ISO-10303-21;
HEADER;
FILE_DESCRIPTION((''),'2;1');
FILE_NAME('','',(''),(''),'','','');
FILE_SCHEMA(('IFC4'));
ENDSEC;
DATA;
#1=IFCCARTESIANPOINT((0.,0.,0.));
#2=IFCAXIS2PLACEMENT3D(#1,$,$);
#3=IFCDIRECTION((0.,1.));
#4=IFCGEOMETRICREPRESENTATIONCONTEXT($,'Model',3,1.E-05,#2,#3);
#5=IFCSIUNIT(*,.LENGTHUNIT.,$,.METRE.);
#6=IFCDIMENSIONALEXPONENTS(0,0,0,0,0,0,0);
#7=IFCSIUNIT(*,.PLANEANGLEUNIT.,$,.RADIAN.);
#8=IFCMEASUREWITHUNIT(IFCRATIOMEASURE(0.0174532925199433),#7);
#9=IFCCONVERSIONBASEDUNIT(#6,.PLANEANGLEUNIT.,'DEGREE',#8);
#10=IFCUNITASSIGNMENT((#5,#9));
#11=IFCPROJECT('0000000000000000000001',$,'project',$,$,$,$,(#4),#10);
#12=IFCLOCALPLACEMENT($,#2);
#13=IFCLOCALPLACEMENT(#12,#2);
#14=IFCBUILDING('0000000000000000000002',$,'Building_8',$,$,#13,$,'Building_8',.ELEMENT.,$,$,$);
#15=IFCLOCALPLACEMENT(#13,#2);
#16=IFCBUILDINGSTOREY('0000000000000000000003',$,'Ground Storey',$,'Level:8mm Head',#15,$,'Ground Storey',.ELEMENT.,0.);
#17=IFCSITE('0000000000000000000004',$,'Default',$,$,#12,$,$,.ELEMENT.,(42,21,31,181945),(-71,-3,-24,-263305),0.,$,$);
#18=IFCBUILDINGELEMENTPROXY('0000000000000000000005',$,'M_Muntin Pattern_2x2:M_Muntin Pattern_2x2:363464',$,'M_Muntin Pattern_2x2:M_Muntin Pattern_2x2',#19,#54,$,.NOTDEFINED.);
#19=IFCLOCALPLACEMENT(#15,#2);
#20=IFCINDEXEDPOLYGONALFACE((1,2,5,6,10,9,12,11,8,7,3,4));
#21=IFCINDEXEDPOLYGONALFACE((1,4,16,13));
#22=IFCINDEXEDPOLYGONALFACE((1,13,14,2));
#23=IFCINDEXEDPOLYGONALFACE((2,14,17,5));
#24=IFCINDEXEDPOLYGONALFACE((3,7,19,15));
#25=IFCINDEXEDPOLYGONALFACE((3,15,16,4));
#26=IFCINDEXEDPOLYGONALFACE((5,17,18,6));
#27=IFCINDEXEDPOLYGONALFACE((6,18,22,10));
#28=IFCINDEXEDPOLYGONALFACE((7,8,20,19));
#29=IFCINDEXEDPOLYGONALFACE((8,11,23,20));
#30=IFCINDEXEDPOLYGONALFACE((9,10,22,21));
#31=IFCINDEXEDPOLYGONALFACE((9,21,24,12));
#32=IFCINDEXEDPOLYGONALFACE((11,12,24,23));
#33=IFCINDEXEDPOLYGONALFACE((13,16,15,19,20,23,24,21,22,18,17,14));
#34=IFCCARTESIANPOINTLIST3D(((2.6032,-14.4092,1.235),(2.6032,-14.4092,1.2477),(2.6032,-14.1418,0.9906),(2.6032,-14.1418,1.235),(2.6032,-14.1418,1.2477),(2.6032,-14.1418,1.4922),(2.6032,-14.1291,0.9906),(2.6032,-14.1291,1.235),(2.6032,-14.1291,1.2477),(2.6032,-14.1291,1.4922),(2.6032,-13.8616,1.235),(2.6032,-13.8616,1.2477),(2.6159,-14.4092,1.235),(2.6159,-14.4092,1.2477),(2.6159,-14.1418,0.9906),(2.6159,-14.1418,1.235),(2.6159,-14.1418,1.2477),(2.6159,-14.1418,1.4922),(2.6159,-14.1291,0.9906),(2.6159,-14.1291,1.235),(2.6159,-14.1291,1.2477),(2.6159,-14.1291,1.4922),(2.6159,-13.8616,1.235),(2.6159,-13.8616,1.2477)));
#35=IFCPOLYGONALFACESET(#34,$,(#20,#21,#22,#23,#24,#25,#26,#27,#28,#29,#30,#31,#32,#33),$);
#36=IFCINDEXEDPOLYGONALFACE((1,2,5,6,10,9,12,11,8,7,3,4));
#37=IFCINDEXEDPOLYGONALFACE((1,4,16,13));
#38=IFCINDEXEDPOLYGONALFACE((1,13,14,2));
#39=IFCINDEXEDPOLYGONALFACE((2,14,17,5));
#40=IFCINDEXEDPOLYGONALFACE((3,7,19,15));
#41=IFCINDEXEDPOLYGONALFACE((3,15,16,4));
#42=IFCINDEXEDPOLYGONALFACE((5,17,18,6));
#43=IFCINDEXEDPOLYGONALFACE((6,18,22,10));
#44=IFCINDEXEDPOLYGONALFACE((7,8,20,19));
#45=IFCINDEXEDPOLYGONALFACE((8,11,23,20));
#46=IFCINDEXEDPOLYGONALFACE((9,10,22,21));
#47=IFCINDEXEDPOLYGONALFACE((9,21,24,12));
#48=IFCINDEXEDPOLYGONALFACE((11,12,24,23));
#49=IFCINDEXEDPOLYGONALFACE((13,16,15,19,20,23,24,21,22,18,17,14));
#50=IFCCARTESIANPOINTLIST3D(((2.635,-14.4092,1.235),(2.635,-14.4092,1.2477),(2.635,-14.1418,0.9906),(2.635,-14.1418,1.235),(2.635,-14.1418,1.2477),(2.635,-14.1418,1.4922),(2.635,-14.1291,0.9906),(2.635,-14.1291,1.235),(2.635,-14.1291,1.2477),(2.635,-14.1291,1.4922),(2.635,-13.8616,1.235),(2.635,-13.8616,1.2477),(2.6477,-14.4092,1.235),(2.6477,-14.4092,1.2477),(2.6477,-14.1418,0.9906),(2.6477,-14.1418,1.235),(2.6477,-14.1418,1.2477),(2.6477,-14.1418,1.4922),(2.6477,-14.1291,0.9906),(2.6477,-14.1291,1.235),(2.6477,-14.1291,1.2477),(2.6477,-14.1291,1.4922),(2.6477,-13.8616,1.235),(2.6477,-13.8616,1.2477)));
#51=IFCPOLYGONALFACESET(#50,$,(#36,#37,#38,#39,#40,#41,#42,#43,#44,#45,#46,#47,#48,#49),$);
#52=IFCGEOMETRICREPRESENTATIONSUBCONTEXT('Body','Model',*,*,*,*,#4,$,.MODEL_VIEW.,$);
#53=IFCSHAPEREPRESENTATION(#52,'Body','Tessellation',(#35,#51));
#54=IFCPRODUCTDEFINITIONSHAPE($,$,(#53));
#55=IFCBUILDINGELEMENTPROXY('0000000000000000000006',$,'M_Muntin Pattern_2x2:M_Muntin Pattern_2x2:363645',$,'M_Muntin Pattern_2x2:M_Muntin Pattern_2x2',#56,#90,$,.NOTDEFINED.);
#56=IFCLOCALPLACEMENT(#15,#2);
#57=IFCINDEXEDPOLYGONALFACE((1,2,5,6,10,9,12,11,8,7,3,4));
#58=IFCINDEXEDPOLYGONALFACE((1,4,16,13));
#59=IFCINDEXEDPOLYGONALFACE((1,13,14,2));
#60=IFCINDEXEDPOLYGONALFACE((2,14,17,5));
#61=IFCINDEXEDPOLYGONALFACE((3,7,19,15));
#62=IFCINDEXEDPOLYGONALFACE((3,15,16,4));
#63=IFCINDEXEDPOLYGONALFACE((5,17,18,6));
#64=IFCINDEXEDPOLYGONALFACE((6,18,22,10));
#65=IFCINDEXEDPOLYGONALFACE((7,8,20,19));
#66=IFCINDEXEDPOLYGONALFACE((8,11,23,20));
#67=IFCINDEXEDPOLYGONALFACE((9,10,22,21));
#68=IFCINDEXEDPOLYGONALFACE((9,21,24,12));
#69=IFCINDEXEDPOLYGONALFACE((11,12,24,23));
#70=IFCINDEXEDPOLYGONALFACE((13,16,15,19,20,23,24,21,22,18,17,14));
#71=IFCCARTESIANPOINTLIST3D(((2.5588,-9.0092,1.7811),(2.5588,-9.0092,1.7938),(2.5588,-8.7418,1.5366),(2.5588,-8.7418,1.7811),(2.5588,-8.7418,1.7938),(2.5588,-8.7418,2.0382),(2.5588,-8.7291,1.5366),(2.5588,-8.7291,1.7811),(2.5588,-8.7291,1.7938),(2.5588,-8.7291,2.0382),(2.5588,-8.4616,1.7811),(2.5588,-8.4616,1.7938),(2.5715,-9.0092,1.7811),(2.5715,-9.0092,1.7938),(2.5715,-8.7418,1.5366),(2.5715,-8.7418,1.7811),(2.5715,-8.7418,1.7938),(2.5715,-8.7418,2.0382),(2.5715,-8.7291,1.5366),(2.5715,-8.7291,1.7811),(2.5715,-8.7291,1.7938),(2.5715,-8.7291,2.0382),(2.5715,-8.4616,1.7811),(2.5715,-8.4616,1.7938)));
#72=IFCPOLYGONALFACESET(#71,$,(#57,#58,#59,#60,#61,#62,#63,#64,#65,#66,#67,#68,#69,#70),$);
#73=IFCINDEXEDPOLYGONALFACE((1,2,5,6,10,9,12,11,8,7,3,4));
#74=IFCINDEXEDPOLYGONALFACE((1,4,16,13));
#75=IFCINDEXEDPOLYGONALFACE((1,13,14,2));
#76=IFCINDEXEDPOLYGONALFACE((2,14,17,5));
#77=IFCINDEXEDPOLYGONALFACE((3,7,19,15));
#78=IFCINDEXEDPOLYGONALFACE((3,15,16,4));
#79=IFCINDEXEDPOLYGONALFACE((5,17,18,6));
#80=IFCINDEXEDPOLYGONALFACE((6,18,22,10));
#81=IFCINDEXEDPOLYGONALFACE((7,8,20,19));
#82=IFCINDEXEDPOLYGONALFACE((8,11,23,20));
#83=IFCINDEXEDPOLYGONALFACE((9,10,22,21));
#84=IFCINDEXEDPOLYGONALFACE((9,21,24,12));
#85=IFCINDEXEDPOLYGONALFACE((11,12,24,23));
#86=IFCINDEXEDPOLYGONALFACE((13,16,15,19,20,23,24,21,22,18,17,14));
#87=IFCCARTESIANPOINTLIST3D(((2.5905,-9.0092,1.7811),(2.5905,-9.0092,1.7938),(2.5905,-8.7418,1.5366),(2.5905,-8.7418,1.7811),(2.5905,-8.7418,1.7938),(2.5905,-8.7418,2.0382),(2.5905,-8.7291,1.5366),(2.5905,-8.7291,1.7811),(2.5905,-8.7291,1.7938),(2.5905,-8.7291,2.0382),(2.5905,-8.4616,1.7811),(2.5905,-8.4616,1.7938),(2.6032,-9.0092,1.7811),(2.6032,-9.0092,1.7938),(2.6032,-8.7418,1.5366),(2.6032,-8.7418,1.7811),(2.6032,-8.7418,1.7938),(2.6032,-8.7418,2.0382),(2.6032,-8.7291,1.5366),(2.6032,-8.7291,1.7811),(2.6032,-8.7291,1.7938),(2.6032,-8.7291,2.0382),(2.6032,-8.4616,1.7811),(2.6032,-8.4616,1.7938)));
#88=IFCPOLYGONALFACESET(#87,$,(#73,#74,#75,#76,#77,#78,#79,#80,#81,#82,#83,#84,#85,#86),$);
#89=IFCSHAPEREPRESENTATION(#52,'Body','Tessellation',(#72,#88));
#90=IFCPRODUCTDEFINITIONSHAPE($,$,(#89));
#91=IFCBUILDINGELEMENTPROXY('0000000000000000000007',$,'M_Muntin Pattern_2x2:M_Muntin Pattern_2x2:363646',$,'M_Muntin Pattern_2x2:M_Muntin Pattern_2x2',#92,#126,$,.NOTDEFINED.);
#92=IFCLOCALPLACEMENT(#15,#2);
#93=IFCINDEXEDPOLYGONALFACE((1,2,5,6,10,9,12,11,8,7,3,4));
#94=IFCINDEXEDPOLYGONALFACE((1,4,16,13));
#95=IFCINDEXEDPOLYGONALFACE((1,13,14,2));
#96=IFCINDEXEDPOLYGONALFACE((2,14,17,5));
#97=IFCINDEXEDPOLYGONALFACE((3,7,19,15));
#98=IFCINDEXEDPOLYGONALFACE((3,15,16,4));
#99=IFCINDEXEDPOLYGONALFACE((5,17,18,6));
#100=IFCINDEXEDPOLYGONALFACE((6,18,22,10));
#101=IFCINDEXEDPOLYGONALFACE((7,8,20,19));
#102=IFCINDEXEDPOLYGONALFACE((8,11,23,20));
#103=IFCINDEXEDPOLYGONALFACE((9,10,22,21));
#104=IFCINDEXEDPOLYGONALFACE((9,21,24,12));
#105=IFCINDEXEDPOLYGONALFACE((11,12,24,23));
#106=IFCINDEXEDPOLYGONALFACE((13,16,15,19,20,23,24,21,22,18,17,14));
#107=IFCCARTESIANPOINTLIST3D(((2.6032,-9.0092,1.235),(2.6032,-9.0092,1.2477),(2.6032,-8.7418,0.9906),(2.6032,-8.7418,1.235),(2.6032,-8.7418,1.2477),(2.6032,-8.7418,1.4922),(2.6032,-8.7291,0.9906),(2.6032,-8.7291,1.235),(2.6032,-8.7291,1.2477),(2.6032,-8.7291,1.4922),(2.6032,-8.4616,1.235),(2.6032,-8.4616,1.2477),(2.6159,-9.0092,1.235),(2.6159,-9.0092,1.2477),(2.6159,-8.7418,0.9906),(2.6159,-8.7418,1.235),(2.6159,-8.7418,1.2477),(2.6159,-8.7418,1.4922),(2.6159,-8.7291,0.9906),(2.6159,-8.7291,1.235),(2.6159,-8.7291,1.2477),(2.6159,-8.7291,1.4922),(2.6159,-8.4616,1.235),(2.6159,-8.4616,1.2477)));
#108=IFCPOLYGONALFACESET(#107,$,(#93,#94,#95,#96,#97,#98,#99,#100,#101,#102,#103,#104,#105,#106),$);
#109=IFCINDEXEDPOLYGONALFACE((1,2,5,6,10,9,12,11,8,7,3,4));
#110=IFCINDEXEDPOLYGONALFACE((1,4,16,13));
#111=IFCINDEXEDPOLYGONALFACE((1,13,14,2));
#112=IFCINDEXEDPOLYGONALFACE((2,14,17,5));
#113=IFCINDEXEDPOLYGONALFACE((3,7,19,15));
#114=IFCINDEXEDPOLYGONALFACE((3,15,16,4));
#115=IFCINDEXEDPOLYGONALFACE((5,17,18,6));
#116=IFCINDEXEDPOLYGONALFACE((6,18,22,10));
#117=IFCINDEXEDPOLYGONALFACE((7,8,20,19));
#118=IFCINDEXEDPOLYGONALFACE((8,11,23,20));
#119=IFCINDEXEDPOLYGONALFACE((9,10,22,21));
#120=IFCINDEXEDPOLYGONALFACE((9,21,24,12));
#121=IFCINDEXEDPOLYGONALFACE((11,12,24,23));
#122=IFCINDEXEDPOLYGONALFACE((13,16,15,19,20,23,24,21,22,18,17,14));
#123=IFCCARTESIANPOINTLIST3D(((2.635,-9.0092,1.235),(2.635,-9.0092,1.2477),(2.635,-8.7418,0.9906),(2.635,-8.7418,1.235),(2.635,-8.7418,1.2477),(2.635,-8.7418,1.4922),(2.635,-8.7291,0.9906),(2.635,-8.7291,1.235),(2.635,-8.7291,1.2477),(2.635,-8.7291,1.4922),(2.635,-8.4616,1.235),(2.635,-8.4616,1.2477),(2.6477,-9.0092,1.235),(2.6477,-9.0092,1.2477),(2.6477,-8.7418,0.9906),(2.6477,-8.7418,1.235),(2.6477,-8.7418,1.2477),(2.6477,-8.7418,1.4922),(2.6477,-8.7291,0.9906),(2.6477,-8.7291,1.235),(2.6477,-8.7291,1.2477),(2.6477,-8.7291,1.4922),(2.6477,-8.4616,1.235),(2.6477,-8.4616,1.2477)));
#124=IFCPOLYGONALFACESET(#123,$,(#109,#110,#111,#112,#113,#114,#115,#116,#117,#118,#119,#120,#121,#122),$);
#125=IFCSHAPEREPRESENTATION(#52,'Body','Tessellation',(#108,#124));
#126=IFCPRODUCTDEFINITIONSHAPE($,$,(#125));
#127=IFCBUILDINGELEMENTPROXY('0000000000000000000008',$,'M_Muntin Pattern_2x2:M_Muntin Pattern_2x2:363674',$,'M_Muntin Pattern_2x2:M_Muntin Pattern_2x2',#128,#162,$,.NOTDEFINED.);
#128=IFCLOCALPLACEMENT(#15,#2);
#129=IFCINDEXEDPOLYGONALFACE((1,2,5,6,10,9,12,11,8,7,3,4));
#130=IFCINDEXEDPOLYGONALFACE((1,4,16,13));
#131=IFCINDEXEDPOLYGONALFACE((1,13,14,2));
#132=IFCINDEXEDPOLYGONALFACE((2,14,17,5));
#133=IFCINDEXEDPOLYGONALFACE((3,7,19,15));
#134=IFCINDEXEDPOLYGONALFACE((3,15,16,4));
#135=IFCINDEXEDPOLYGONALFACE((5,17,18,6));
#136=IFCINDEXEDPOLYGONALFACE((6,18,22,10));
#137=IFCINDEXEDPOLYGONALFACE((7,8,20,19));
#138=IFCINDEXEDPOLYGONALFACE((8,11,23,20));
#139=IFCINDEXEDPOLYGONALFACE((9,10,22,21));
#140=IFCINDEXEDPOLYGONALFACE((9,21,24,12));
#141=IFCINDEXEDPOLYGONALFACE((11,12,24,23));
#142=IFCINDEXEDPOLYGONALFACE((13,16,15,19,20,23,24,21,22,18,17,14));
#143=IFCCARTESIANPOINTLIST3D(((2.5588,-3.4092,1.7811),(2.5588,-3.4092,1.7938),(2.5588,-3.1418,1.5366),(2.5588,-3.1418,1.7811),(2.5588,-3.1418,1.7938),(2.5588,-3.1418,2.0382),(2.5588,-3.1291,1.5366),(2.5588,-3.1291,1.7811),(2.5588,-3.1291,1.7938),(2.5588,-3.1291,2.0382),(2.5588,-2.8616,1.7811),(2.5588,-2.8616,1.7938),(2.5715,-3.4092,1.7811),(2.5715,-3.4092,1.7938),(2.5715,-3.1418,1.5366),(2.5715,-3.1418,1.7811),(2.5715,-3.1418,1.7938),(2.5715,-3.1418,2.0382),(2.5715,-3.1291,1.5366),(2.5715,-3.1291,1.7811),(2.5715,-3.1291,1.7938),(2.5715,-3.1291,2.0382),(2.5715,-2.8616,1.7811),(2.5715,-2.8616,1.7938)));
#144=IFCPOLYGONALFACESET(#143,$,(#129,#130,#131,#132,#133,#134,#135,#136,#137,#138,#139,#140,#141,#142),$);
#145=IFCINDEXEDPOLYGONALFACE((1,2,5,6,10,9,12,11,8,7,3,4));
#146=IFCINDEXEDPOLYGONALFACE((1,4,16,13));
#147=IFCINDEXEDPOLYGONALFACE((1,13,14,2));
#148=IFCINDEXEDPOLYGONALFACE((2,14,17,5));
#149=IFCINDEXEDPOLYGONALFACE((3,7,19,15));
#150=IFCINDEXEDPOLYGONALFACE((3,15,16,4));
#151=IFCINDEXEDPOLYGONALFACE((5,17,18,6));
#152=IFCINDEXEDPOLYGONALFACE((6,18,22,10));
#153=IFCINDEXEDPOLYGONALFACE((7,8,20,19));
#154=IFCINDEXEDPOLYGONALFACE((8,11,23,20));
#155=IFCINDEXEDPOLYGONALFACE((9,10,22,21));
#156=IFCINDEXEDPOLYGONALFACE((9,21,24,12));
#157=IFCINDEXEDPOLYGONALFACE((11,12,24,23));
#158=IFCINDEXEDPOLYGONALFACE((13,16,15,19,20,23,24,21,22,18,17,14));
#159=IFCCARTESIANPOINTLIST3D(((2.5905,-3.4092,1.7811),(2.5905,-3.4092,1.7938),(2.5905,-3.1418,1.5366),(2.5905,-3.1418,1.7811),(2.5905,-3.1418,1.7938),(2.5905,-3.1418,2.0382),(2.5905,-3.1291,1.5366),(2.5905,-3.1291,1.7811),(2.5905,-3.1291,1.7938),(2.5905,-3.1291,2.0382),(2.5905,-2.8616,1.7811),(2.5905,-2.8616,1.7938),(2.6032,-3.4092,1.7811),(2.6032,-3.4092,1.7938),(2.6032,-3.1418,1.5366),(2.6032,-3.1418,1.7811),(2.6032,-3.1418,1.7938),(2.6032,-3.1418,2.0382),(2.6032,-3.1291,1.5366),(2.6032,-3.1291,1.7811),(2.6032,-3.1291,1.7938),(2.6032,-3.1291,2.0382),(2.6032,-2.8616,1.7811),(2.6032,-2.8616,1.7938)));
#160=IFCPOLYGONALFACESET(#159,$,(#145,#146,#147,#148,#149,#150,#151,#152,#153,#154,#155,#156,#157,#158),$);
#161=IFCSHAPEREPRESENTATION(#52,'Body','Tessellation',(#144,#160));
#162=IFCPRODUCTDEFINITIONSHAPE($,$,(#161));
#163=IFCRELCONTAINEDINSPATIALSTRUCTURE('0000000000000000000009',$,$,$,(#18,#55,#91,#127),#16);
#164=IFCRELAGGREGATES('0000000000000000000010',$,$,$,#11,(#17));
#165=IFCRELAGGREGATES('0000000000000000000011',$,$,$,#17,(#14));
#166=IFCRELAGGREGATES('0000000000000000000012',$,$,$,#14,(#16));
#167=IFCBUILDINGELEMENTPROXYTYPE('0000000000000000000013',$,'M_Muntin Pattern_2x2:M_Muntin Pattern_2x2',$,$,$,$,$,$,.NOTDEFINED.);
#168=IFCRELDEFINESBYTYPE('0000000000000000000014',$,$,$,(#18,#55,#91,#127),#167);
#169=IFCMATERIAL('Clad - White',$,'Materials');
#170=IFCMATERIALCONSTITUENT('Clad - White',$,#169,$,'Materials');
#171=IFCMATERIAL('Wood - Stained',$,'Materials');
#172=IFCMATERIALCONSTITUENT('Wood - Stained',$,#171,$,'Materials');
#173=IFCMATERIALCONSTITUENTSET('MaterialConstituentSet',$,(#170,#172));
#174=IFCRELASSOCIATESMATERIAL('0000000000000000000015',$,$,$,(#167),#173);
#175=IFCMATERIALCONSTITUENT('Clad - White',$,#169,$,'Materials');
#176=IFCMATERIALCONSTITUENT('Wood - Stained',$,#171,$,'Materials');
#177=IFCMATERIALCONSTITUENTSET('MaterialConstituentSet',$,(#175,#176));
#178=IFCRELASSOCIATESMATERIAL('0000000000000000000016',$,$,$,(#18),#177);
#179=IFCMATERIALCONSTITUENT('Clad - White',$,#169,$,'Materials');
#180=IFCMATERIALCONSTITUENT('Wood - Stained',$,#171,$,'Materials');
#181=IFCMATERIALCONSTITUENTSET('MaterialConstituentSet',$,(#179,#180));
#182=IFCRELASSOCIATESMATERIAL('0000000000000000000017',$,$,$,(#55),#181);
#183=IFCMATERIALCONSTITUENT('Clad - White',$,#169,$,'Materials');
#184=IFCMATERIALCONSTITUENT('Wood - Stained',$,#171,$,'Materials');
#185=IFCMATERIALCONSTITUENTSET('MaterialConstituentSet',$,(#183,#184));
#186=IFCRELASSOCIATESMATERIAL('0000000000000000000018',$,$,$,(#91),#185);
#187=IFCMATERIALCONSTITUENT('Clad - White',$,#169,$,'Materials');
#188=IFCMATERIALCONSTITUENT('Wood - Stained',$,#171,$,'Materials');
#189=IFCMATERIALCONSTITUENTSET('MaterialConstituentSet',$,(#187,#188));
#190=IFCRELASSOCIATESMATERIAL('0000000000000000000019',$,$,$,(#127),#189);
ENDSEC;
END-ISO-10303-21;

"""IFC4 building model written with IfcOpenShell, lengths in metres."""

from ifc_helpers import new_model, entity, si_unit, converted_unit, direction, frame, origin, place, context, subcontext, project, spatial, indexed_curve, outline, extrude, source, transform, mapped, material, constituent, constituent_set, type_object, type_shapes, element, save


model = new_model("IFC4")

# Units and contexts
model_context = context("Model", 3, precision=1e-05, world=origin(), true_north=direction((0.0, 1.0)))
body_context = subcontext(model_context, "Body", "Model", "MODEL_VIEW")
ifc_project = project(units=[si_unit("LENGTHUNIT", "METRE"), converted_unit("PLANEANGLEUNIT", "DEGREE", entity("IfcRatioMeasure", 0.0174532925199433), si_unit("PLANEANGLEUNIT", "RADIAN"), dimensions=[0, 0, 0, 0, 0, 0, 0])], contexts=[model_context])

# Site, building, storey
site_placement = place(None, origin())
site = spatial("IfcSite", under=ifc_project, at=site_placement, Name="Default", CompositionType="ELEMENT", RefLatitude=(42, 21, 31, 181945), RefLongitude=(-71, -3, -24, -263305), RefElevation=0.0)
building_placement = place(site_placement, origin())
building = spatial("IfcBuilding", under=site, at=building_placement, Name="Building_8", LongName="Building_8", CompositionType="ELEMENT")
storey_placement = place(building_placement, origin())
storey = spatial("IfcBuildingStorey", under=building, at=storey_placement, Name="Ground Storey", ObjectType="Level:8mm Head", LongName="Ground Storey", CompositionType="ELEMENT", Elevation=0.0)

# Building element proxies
ifc_material_1 = material(Name="Clad - White", Category="Materials")
ifc_material_2 = material(Name="Wood - Stained", Category="Materials")
ifc_constituent_1 = constituent(ifc_material_1, Name="Clad - White", Category="Materials")
ifc_constituent_2 = constituent(ifc_material_2, Name="Wood - Stained", Category="Materials")
ifc_constituent_set_1 = constituent_set(constituents=[ifc_constituent_1, ifc_constituent_2], Name="MaterialConstituentSet")
building_element_proxy_type_1 = type_object("IfcBuildingElementProxyType", Name="M_Muntin Pattern_2x2:M_Muntin Pattern_2x2", PredefinedType="NOTDEFINED", material=ifc_constituent_set_1)
shared_shape_1 = source(origin(), body_context, "Body", "SweptSolid", [
    extrude(outline(indexed_curve([(0.0064, -0.0064), (0.2508, -0.0064), (0.2508, 0.0063), (0.0064, 0.0063), (0.0064, 0.2738), (-0.0063, 0.2738), (-0.0063, 0.0063), (-0.2508, 0.0063), (-0.2508, -0.0064), (-0.0063, -0.0064), (-0.0063, -0.2738), (0.0064, -0.2738), (0.0064, -0.0064)], self_intersect=False)), frame((0.0, 0.0095, 0.2508), z_axis=(0.0, 1.0, 0.0), x_axis=(0.0, 0.0, 1.0)), (0.0, 0.0, 1.0), 0.0127),
    extrude(outline(indexed_curve([(0.0064, -0.0064), (0.2508, -0.0064), (0.2508, 0.0063), (0.0064, 0.0063), (0.0064, 0.2738), (-0.0063, 0.2738), (-0.0063, 0.0063), (-0.2508, 0.0063), (-0.2508, -0.0064), (-0.0063, -0.0064), (-0.0063, -0.2738), (0.0064, -0.2738), (0.0064, -0.0064)], self_intersect=False)), frame((0.0, -0.0222, 0.2508), z_axis=(0.0, 1.0, 0.0), x_axis=(0.0, 0.0, 1.0)), (0.0, 0.0, 1.0), 0.0127),
])
type_shapes(building_element_proxy_type_1, [shared_shape_1])
ifc_constituent_3 = constituent(ifc_material_1, Name="Clad - White", Category="Materials")
ifc_constituent_4 = constituent(ifc_material_2, Name="Wood - Stained", Category="Materials")
ifc_constituent_set_2 = constituent_set(constituents=[ifc_constituent_3, ifc_constituent_4], Name="MaterialConstituentSet")
proxy_1_placement = place(storey_placement, frame((2.6255, -14.1354, 0.9906), z_axis=(0.0, 0.0, 1.0), x_axis=(0.0, 1.0, 0.0)))
element("IfcBuildingElementProxy", 1, at=proxy_1_placement, inside=storey, type_object=building_element_proxy_type_1, material=ifc_constituent_set_2, Name="M_Muntin Pattern_2x2:M_Muntin Pattern_2x2:363464", ObjectType="M_Muntin Pattern_2x2:M_Muntin Pattern_2x2", PredefinedType="NOTDEFINED", context=body_context, shape_type="MappedRepresentation", body=[
    mapped(shared_shape_1, transform((0.0, 0.0, 0.0), scale=1.0)),
])
ifc_constituent_5 = constituent(ifc_material_1, Name="Clad - White", Category="Materials")
ifc_constituent_6 = constituent(ifc_material_2, Name="Wood - Stained", Category="Materials")
ifc_constituent_set_3 = constituent_set(constituents=[ifc_constituent_5, ifc_constituent_6], Name="MaterialConstituentSet")
proxy_2_placement = place(storey_placement, frame((2.581, -8.7354, 1.5366), z_axis=(0.0, 0.0, 1.0), x_axis=(0.0, 1.0, 0.0)))
element("IfcBuildingElementProxy", 2, at=proxy_2_placement, inside=storey, type_object=building_element_proxy_type_1, material=ifc_constituent_set_3, Name="M_Muntin Pattern_2x2:M_Muntin Pattern_2x2:363645", ObjectType="M_Muntin Pattern_2x2:M_Muntin Pattern_2x2", PredefinedType="NOTDEFINED", context=body_context, shape_type="MappedRepresentation", body=[
    mapped(shared_shape_1, transform((0.0, 0.0, 0.0), scale=1.0)),
])
ifc_constituent_7 = constituent(ifc_material_1, Name="Clad - White", Category="Materials")
ifc_constituent_8 = constituent(ifc_material_2, Name="Wood - Stained", Category="Materials")
ifc_constituent_set_4 = constituent_set(constituents=[ifc_constituent_7, ifc_constituent_8], Name="MaterialConstituentSet")
proxy_3_placement = place(storey_placement, frame((2.6255, -8.7354, 0.9906), z_axis=(0.0, 0.0, 1.0), x_axis=(0.0, 1.0, 0.0)))
element("IfcBuildingElementProxy", 3, at=proxy_3_placement, inside=storey, type_object=building_element_proxy_type_1, material=ifc_constituent_set_4, Name="M_Muntin Pattern_2x2:M_Muntin Pattern_2x2:363646", ObjectType="M_Muntin Pattern_2x2:M_Muntin Pattern_2x2", PredefinedType="NOTDEFINED", context=body_context, shape_type="MappedRepresentation", body=[
    mapped(shared_shape_1, transform((0.0, 0.0, 0.0), scale=1.0)),
])
ifc_constituent_9 = constituent(ifc_material_1, Name="Clad - White", Category="Materials")
ifc_constituent_10 = constituent(ifc_material_2, Name="Wood - Stained", Category="Materials")
ifc_constituent_set_5 = constituent_set(constituents=[ifc_constituent_9, ifc_constituent_10], Name="MaterialConstituentSet")
proxy_4_placement = place(storey_placement, frame((2.581, -3.1354, 1.5366), z_axis=(0.0, 0.0, 1.0), x_axis=(0.0, 1.0, 0.0)))
element("IfcBuildingElementProxy", 4, at=proxy_4_placement, inside=storey, type_object=building_element_proxy_type_1, material=ifc_constituent_set_5, Name="M_Muntin Pattern_2x2:M_Muntin Pattern_2x2:363674", ObjectType="M_Muntin Pattern_2x2:M_Muntin Pattern_2x2", PredefinedType="NOTDEFINED", context=body_context, shape_type="MappedRepresentation", body=[
    mapped(shared_shape_1, transform((0.0, 0.0, 0.0), scale=1.0)),
])

save(model, "model.ifc")
